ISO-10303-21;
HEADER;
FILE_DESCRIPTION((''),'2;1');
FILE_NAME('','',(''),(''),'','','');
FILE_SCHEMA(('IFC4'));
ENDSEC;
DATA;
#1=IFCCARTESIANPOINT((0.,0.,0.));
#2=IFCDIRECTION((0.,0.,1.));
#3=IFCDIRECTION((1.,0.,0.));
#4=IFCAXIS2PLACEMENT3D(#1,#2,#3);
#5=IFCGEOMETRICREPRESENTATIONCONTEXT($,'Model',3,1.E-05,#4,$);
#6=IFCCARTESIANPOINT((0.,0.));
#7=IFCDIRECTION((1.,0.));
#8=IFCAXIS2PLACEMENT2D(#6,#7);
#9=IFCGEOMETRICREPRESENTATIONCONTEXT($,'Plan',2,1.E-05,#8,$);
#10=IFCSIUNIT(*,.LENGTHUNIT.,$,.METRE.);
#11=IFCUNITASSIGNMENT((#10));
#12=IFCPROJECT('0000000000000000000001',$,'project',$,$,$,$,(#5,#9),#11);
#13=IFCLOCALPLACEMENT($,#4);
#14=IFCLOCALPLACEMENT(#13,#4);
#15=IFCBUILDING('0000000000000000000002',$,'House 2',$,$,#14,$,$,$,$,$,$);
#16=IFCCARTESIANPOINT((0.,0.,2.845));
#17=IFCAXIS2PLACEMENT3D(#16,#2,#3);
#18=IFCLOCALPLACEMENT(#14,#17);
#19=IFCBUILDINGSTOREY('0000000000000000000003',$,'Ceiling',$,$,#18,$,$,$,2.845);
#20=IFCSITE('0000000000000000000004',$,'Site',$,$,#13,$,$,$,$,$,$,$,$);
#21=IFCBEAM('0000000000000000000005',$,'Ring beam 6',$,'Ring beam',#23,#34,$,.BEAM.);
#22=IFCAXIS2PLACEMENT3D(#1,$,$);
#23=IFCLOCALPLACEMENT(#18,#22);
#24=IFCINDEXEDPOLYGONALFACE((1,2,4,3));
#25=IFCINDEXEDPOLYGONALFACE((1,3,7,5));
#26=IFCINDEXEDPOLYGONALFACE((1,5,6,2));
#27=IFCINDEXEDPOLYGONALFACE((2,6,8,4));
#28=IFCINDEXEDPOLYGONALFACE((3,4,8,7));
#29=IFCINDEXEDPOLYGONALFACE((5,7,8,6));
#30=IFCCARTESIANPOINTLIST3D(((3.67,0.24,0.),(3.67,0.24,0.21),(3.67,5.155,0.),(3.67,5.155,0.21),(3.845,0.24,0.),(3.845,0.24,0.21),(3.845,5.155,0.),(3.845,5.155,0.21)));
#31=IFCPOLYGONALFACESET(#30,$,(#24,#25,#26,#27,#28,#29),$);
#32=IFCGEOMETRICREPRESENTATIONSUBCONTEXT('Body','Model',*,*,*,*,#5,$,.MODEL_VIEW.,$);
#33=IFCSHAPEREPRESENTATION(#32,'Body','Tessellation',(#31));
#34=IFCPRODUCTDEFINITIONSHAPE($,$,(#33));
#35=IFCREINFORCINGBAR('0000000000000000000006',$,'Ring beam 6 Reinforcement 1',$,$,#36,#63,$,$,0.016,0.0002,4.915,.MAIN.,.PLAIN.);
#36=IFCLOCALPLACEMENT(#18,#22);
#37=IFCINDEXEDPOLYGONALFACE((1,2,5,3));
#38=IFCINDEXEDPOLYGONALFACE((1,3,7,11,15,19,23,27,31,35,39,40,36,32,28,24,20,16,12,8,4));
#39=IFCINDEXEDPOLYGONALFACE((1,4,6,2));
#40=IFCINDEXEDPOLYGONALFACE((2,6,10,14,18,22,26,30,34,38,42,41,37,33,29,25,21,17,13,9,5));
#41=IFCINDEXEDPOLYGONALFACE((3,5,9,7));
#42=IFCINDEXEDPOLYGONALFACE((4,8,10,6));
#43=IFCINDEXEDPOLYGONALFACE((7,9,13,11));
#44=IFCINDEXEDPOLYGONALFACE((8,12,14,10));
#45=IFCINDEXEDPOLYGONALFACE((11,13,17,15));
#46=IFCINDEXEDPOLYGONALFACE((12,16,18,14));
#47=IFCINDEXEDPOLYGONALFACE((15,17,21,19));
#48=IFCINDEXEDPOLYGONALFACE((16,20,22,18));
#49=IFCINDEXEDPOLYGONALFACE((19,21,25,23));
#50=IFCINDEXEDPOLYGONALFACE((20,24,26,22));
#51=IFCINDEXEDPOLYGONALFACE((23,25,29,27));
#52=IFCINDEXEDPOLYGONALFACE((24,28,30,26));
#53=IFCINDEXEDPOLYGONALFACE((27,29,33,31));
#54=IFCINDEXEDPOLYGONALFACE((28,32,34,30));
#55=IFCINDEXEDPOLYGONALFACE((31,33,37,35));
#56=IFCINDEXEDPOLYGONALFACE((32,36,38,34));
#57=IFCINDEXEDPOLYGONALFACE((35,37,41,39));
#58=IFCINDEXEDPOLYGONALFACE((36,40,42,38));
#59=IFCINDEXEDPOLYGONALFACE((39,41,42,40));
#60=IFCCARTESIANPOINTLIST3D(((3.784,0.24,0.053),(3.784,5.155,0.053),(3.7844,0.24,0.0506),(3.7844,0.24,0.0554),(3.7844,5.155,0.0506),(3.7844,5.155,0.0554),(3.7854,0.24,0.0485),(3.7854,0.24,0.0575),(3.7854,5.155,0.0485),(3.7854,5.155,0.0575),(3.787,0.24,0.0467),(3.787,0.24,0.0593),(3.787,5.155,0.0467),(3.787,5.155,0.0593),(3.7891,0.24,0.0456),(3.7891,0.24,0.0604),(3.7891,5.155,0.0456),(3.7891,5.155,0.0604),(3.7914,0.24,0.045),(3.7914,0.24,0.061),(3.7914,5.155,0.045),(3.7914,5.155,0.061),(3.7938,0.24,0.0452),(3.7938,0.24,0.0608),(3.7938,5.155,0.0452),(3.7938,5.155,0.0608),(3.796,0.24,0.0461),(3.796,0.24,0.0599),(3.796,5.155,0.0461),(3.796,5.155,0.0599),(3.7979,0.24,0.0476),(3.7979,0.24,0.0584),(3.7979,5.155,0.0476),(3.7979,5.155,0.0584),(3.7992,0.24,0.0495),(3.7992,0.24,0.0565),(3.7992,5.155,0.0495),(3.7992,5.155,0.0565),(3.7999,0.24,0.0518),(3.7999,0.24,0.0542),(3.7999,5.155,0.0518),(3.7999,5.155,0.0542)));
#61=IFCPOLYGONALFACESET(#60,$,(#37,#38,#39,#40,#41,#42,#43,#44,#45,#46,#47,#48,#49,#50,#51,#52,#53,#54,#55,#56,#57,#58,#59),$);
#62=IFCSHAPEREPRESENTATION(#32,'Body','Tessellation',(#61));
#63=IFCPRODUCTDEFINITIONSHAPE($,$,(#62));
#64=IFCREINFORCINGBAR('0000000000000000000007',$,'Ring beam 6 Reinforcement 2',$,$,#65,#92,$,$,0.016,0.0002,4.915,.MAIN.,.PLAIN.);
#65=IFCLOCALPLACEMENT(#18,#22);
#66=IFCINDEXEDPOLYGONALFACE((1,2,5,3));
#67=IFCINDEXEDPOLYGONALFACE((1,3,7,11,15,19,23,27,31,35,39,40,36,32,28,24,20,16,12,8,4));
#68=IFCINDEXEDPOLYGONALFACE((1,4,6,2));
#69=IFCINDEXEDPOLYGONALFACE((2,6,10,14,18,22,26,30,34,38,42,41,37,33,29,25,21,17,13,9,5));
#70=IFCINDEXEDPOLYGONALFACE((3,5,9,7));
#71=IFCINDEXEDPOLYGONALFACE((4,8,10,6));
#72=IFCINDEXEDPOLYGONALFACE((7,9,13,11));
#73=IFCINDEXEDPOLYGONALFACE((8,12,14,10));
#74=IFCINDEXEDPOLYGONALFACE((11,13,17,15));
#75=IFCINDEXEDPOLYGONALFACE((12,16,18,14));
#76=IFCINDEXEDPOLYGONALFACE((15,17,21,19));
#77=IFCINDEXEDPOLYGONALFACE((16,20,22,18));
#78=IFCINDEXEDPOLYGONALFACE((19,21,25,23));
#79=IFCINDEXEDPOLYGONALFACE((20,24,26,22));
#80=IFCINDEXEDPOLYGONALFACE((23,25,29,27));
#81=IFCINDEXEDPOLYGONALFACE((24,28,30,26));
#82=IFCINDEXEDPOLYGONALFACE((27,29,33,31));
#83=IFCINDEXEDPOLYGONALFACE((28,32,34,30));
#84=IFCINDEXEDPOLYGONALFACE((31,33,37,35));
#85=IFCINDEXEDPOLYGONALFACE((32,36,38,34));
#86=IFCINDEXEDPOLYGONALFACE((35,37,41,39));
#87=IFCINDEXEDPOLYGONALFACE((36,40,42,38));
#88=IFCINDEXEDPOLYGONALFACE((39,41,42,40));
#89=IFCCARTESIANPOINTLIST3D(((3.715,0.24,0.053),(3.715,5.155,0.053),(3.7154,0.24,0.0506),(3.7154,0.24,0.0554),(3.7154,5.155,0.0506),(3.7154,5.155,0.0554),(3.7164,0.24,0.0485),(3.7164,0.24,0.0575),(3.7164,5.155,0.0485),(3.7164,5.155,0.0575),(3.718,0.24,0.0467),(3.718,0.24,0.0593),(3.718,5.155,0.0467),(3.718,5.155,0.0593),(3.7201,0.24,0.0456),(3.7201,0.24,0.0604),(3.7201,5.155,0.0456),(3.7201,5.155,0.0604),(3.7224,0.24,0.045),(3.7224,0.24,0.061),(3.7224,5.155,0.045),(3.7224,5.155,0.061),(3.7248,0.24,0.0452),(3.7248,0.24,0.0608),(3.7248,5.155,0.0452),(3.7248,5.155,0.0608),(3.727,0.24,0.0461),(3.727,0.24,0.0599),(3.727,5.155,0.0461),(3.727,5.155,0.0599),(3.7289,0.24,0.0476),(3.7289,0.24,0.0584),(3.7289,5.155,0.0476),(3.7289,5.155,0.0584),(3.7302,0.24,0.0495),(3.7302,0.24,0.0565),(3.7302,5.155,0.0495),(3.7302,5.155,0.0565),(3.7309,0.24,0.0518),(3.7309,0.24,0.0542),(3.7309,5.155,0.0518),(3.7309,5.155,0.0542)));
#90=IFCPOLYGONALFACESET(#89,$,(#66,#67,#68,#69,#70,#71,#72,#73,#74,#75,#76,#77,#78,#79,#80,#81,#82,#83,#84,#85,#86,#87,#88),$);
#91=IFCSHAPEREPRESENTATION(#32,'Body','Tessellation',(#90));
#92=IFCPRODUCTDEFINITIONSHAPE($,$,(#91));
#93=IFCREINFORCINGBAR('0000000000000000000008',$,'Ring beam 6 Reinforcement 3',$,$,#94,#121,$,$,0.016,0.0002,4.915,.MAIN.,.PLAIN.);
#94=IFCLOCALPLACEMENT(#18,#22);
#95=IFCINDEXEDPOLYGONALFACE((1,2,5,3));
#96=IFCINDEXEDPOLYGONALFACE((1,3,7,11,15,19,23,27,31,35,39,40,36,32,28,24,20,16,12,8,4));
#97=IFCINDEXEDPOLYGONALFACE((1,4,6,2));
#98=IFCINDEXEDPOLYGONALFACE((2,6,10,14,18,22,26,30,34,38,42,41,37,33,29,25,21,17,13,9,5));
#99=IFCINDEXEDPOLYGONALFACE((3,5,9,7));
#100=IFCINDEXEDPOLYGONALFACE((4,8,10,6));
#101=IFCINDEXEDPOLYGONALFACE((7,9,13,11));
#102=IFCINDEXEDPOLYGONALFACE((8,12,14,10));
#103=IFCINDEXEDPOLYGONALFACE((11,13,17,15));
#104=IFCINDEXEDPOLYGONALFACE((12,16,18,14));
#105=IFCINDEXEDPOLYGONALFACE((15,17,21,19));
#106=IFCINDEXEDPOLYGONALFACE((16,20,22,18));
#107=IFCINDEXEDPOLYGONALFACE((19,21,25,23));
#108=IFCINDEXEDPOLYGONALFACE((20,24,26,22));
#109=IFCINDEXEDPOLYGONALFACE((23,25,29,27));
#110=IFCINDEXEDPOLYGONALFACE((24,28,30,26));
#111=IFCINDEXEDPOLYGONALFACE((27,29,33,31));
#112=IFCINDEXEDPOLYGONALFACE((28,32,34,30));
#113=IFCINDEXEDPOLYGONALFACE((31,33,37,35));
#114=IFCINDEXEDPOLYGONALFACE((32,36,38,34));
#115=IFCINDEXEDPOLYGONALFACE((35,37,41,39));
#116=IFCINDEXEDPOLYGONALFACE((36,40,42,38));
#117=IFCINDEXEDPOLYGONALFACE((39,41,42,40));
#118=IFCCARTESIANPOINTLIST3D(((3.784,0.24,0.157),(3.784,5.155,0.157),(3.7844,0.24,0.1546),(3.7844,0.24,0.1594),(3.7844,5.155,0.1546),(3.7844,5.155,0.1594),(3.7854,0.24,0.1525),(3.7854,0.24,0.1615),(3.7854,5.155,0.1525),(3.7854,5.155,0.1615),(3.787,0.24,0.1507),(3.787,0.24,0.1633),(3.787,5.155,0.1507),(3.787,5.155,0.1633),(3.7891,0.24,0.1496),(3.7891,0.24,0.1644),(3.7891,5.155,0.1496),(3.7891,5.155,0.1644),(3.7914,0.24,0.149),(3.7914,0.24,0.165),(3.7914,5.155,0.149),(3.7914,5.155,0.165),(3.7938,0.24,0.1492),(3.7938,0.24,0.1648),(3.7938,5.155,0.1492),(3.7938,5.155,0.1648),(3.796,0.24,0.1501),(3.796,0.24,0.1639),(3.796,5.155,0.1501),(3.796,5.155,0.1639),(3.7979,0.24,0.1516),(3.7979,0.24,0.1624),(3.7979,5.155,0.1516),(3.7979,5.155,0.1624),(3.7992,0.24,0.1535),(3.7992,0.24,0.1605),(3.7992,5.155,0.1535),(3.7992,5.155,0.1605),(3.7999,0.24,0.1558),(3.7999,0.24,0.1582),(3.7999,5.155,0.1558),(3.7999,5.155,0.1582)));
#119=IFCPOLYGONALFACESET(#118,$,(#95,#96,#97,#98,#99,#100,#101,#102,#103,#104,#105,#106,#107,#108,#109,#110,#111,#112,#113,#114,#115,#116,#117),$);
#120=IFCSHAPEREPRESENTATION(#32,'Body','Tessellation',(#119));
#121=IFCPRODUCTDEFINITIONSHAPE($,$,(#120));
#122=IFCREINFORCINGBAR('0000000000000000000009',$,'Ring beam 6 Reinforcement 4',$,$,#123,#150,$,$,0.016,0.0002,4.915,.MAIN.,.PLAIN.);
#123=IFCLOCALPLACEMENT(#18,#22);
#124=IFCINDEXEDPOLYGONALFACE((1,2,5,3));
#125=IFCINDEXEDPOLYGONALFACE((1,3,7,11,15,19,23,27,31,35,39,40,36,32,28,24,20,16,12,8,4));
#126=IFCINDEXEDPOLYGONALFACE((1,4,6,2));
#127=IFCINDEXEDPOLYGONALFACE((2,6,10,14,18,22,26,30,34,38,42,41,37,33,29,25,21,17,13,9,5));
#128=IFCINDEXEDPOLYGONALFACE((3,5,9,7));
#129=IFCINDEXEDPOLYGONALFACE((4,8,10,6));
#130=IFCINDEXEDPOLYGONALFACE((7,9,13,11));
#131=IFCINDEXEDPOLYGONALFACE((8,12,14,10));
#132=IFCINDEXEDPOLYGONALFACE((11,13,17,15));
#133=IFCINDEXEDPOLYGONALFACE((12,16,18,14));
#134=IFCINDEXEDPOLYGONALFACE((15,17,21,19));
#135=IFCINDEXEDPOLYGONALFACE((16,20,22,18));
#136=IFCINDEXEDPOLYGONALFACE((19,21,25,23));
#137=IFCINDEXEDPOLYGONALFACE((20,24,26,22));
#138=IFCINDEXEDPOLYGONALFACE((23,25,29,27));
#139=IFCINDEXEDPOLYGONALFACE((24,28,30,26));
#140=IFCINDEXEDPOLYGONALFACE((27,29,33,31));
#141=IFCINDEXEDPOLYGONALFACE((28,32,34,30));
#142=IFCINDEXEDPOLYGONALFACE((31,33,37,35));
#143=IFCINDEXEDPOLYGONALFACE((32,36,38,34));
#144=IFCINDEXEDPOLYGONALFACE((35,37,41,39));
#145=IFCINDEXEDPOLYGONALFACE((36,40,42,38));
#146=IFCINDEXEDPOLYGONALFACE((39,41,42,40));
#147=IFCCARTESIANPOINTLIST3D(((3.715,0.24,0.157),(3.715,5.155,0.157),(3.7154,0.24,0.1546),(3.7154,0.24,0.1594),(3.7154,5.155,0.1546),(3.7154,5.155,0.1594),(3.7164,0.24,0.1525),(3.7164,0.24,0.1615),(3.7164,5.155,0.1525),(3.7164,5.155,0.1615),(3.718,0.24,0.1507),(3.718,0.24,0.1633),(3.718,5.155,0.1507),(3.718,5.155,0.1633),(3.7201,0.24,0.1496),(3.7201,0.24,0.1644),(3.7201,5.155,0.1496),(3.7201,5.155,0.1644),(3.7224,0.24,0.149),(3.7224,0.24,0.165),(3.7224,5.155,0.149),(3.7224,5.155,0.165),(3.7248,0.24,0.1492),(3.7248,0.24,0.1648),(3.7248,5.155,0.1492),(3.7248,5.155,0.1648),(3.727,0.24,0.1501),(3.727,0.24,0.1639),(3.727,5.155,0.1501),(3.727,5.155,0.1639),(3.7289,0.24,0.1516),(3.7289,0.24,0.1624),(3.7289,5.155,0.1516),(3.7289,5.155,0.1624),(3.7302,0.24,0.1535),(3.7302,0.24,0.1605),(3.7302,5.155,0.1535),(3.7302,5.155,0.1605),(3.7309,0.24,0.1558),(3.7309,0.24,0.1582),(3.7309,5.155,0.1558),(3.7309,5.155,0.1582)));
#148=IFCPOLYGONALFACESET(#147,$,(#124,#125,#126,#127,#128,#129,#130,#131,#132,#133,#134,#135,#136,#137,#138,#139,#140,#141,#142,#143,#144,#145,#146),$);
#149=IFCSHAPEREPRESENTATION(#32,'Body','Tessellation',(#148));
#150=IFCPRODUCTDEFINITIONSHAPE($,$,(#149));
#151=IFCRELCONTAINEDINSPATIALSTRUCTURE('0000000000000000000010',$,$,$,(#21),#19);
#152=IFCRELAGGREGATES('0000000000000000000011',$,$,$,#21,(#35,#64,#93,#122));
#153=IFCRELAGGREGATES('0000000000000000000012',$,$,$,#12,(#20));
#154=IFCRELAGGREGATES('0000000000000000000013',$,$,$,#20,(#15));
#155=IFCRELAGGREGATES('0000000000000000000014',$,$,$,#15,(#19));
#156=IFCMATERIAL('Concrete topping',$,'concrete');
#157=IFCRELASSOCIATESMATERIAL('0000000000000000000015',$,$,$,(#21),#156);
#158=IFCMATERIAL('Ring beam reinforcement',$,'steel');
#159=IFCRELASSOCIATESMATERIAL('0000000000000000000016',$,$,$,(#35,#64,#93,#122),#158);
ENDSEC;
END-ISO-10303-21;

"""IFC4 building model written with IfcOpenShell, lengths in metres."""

from ifc_helpers import new_model, si_unit, frame, origin_with_axes, origin_2d, origin_2d_with_axis, place, context, subcontext, project, spatial, circle_curve, rectangle, outline, extrude, material, element, aggregate, save


model = new_model("IFC4")

# Units and contexts
model_context = context("Model", 3, precision=1e-05, world=origin_with_axes())
plan_context = context("Plan", 2, precision=1e-05, world=origin_2d_with_axis())
body_context = subcontext(model_context, "Body", "Model", "MODEL_VIEW")
ifc_project = project(units=[si_unit("LENGTHUNIT", "METRE")], contexts=[model_context, plan_context])

# Site, building, storey
site_placement = place(None, origin_with_axes())
site = spatial("IfcSite", under=ifc_project, at=site_placement, Name="Site")
building_placement = place(site_placement, origin_with_axes())
building = spatial("IfcBuilding", under=site, at=building_placement, Name="House 2")
storey_placement = place(building_placement, frame((0.0, 0.0, 2.845), z_axis=(0.0, 0.0, 1.0), x_axis=(1.0, 0.0, 0.0)))
storey = spatial("IfcBuildingStorey", under=building, at=storey_placement, Name="Ceiling", Elevation=2.845)

# Beam
ifc_material_1 = material(Name="Concrete topping", Category="concrete")
beam_1_placement = place(storey_placement, frame((3.7575, 0.24, 0.105), z_axis=(0.0, 0.0, 1.0), x_axis=(0.0, 1.0, 0.0)))
beam_1 = element("IfcBeam", 1, at=beam_1_placement, inside=storey, material=ifc_material_1, Name="Ring beam 6", ObjectType="Ring beam", PredefinedType="BEAM", context=body_context, shape_type="SweptSolid", body=[
    extrude(rectangle(XDim=0.175, YDim=0.21), frame((0.0, 0.0, 0.0), z_axis=(1.0, 0.0, 0.0), x_axis=(0.0, 1.0, 0.0)), (0.0, 0.0, 1.0), 4.915),
])

# Reinforcing bars
ifc_material_2 = material(Name="Ring beam reinforcement", Category="steel")
reinforcing_bar_1_placement = place(beam_1_placement, frame((0.0, -0.0345, -0.052), z_axis=(0.0, 0.0, 1.0), x_axis=(1.0, 0.0, 0.0)))
reinforcing_bar_1 = element("IfcReinforcingBar", 2, at=reinforcing_bar_1_placement, material=ifc_material_2, Name="Ring beam 6 Reinforcement 1", BarLength=4.915, BarSurface="PLAIN", CrossSectionArea=0.0002, NominalDiameter=0.016, PredefinedType="MAIN", context=body_context, shape_type="SweptSolid", body=[
    extrude(outline(circle_curve(origin_2d(), 0.008)), frame((0.0, 0.0, 0.0), z_axis=(1.0, 0.0, 0.0), x_axis=(0.0, 1.0, 0.0)), (0.0, 0.0, 1.0), 4.915),
])
reinforcing_bar_2_placement = place(beam_1_placement, frame((0.0, 0.0345, -0.052), z_axis=(0.0, 0.0, 1.0), x_axis=(1.0, 0.0, 0.0)))
reinforcing_bar_2 = element("IfcReinforcingBar", 3, at=reinforcing_bar_2_placement, material=ifc_material_2, Name="Ring beam 6 Reinforcement 2", BarLength=4.915, BarSurface="PLAIN", CrossSectionArea=0.0002, NominalDiameter=0.016, PredefinedType="MAIN", context=body_context, shape_type="SweptSolid", body=[
    extrude(outline(circle_curve(origin_2d(), 0.008)), frame((0.0, 0.0, 0.0), z_axis=(1.0, 0.0, 0.0), x_axis=(0.0, 1.0, 0.0)), (0.0, 0.0, 1.0), 4.915),
])
reinforcing_bar_3_placement = place(beam_1_placement, frame((0.0, -0.0345, 0.052), z_axis=(0.0, 0.0, 1.0), x_axis=(1.0, 0.0, 0.0)))
reinforcing_bar_3 = element("IfcReinforcingBar", 4, at=reinforcing_bar_3_placement, material=ifc_material_2, Name="Ring beam 6 Reinforcement 3", BarLength=4.915, BarSurface="PLAIN", CrossSectionArea=0.0002, NominalDiameter=0.016, PredefinedType="MAIN", context=body_context, shape_type="SweptSolid", body=[
    extrude(outline(circle_curve(origin_2d(), 0.008)), frame((0.0, 0.0, 0.0), z_axis=(1.0, 0.0, 0.0), x_axis=(0.0, 1.0, 0.0)), (0.0, 0.0, 1.0), 4.915),
])
reinforcing_bar_4_placement = place(beam_1_placement, frame((0.0, 0.0345, 0.052), z_axis=(0.0, 0.0, 1.0), x_axis=(1.0, 0.0, 0.0)))
reinforcing_bar_4 = element("IfcReinforcingBar", 5, at=reinforcing_bar_4_placement, material=ifc_material_2, Name="Ring beam 6 Reinforcement 4", BarLength=4.915, BarSurface="PLAIN", CrossSectionArea=0.0002, NominalDiameter=0.016, PredefinedType="MAIN", context=body_context, shape_type="SweptSolid", body=[
    extrude(outline(circle_curve(origin_2d(), 0.008)), frame((0.0, 0.0, 0.0), z_axis=(1.0, 0.0, 0.0), x_axis=(0.0, 1.0, 0.0)), (0.0, 0.0, 1.0), 4.915),
])
aggregate(beam_1, [reinforcing_bar_1, reinforcing_bar_2, reinforcing_bar_3, reinforcing_bar_4])

save(model, "model.ifc")
